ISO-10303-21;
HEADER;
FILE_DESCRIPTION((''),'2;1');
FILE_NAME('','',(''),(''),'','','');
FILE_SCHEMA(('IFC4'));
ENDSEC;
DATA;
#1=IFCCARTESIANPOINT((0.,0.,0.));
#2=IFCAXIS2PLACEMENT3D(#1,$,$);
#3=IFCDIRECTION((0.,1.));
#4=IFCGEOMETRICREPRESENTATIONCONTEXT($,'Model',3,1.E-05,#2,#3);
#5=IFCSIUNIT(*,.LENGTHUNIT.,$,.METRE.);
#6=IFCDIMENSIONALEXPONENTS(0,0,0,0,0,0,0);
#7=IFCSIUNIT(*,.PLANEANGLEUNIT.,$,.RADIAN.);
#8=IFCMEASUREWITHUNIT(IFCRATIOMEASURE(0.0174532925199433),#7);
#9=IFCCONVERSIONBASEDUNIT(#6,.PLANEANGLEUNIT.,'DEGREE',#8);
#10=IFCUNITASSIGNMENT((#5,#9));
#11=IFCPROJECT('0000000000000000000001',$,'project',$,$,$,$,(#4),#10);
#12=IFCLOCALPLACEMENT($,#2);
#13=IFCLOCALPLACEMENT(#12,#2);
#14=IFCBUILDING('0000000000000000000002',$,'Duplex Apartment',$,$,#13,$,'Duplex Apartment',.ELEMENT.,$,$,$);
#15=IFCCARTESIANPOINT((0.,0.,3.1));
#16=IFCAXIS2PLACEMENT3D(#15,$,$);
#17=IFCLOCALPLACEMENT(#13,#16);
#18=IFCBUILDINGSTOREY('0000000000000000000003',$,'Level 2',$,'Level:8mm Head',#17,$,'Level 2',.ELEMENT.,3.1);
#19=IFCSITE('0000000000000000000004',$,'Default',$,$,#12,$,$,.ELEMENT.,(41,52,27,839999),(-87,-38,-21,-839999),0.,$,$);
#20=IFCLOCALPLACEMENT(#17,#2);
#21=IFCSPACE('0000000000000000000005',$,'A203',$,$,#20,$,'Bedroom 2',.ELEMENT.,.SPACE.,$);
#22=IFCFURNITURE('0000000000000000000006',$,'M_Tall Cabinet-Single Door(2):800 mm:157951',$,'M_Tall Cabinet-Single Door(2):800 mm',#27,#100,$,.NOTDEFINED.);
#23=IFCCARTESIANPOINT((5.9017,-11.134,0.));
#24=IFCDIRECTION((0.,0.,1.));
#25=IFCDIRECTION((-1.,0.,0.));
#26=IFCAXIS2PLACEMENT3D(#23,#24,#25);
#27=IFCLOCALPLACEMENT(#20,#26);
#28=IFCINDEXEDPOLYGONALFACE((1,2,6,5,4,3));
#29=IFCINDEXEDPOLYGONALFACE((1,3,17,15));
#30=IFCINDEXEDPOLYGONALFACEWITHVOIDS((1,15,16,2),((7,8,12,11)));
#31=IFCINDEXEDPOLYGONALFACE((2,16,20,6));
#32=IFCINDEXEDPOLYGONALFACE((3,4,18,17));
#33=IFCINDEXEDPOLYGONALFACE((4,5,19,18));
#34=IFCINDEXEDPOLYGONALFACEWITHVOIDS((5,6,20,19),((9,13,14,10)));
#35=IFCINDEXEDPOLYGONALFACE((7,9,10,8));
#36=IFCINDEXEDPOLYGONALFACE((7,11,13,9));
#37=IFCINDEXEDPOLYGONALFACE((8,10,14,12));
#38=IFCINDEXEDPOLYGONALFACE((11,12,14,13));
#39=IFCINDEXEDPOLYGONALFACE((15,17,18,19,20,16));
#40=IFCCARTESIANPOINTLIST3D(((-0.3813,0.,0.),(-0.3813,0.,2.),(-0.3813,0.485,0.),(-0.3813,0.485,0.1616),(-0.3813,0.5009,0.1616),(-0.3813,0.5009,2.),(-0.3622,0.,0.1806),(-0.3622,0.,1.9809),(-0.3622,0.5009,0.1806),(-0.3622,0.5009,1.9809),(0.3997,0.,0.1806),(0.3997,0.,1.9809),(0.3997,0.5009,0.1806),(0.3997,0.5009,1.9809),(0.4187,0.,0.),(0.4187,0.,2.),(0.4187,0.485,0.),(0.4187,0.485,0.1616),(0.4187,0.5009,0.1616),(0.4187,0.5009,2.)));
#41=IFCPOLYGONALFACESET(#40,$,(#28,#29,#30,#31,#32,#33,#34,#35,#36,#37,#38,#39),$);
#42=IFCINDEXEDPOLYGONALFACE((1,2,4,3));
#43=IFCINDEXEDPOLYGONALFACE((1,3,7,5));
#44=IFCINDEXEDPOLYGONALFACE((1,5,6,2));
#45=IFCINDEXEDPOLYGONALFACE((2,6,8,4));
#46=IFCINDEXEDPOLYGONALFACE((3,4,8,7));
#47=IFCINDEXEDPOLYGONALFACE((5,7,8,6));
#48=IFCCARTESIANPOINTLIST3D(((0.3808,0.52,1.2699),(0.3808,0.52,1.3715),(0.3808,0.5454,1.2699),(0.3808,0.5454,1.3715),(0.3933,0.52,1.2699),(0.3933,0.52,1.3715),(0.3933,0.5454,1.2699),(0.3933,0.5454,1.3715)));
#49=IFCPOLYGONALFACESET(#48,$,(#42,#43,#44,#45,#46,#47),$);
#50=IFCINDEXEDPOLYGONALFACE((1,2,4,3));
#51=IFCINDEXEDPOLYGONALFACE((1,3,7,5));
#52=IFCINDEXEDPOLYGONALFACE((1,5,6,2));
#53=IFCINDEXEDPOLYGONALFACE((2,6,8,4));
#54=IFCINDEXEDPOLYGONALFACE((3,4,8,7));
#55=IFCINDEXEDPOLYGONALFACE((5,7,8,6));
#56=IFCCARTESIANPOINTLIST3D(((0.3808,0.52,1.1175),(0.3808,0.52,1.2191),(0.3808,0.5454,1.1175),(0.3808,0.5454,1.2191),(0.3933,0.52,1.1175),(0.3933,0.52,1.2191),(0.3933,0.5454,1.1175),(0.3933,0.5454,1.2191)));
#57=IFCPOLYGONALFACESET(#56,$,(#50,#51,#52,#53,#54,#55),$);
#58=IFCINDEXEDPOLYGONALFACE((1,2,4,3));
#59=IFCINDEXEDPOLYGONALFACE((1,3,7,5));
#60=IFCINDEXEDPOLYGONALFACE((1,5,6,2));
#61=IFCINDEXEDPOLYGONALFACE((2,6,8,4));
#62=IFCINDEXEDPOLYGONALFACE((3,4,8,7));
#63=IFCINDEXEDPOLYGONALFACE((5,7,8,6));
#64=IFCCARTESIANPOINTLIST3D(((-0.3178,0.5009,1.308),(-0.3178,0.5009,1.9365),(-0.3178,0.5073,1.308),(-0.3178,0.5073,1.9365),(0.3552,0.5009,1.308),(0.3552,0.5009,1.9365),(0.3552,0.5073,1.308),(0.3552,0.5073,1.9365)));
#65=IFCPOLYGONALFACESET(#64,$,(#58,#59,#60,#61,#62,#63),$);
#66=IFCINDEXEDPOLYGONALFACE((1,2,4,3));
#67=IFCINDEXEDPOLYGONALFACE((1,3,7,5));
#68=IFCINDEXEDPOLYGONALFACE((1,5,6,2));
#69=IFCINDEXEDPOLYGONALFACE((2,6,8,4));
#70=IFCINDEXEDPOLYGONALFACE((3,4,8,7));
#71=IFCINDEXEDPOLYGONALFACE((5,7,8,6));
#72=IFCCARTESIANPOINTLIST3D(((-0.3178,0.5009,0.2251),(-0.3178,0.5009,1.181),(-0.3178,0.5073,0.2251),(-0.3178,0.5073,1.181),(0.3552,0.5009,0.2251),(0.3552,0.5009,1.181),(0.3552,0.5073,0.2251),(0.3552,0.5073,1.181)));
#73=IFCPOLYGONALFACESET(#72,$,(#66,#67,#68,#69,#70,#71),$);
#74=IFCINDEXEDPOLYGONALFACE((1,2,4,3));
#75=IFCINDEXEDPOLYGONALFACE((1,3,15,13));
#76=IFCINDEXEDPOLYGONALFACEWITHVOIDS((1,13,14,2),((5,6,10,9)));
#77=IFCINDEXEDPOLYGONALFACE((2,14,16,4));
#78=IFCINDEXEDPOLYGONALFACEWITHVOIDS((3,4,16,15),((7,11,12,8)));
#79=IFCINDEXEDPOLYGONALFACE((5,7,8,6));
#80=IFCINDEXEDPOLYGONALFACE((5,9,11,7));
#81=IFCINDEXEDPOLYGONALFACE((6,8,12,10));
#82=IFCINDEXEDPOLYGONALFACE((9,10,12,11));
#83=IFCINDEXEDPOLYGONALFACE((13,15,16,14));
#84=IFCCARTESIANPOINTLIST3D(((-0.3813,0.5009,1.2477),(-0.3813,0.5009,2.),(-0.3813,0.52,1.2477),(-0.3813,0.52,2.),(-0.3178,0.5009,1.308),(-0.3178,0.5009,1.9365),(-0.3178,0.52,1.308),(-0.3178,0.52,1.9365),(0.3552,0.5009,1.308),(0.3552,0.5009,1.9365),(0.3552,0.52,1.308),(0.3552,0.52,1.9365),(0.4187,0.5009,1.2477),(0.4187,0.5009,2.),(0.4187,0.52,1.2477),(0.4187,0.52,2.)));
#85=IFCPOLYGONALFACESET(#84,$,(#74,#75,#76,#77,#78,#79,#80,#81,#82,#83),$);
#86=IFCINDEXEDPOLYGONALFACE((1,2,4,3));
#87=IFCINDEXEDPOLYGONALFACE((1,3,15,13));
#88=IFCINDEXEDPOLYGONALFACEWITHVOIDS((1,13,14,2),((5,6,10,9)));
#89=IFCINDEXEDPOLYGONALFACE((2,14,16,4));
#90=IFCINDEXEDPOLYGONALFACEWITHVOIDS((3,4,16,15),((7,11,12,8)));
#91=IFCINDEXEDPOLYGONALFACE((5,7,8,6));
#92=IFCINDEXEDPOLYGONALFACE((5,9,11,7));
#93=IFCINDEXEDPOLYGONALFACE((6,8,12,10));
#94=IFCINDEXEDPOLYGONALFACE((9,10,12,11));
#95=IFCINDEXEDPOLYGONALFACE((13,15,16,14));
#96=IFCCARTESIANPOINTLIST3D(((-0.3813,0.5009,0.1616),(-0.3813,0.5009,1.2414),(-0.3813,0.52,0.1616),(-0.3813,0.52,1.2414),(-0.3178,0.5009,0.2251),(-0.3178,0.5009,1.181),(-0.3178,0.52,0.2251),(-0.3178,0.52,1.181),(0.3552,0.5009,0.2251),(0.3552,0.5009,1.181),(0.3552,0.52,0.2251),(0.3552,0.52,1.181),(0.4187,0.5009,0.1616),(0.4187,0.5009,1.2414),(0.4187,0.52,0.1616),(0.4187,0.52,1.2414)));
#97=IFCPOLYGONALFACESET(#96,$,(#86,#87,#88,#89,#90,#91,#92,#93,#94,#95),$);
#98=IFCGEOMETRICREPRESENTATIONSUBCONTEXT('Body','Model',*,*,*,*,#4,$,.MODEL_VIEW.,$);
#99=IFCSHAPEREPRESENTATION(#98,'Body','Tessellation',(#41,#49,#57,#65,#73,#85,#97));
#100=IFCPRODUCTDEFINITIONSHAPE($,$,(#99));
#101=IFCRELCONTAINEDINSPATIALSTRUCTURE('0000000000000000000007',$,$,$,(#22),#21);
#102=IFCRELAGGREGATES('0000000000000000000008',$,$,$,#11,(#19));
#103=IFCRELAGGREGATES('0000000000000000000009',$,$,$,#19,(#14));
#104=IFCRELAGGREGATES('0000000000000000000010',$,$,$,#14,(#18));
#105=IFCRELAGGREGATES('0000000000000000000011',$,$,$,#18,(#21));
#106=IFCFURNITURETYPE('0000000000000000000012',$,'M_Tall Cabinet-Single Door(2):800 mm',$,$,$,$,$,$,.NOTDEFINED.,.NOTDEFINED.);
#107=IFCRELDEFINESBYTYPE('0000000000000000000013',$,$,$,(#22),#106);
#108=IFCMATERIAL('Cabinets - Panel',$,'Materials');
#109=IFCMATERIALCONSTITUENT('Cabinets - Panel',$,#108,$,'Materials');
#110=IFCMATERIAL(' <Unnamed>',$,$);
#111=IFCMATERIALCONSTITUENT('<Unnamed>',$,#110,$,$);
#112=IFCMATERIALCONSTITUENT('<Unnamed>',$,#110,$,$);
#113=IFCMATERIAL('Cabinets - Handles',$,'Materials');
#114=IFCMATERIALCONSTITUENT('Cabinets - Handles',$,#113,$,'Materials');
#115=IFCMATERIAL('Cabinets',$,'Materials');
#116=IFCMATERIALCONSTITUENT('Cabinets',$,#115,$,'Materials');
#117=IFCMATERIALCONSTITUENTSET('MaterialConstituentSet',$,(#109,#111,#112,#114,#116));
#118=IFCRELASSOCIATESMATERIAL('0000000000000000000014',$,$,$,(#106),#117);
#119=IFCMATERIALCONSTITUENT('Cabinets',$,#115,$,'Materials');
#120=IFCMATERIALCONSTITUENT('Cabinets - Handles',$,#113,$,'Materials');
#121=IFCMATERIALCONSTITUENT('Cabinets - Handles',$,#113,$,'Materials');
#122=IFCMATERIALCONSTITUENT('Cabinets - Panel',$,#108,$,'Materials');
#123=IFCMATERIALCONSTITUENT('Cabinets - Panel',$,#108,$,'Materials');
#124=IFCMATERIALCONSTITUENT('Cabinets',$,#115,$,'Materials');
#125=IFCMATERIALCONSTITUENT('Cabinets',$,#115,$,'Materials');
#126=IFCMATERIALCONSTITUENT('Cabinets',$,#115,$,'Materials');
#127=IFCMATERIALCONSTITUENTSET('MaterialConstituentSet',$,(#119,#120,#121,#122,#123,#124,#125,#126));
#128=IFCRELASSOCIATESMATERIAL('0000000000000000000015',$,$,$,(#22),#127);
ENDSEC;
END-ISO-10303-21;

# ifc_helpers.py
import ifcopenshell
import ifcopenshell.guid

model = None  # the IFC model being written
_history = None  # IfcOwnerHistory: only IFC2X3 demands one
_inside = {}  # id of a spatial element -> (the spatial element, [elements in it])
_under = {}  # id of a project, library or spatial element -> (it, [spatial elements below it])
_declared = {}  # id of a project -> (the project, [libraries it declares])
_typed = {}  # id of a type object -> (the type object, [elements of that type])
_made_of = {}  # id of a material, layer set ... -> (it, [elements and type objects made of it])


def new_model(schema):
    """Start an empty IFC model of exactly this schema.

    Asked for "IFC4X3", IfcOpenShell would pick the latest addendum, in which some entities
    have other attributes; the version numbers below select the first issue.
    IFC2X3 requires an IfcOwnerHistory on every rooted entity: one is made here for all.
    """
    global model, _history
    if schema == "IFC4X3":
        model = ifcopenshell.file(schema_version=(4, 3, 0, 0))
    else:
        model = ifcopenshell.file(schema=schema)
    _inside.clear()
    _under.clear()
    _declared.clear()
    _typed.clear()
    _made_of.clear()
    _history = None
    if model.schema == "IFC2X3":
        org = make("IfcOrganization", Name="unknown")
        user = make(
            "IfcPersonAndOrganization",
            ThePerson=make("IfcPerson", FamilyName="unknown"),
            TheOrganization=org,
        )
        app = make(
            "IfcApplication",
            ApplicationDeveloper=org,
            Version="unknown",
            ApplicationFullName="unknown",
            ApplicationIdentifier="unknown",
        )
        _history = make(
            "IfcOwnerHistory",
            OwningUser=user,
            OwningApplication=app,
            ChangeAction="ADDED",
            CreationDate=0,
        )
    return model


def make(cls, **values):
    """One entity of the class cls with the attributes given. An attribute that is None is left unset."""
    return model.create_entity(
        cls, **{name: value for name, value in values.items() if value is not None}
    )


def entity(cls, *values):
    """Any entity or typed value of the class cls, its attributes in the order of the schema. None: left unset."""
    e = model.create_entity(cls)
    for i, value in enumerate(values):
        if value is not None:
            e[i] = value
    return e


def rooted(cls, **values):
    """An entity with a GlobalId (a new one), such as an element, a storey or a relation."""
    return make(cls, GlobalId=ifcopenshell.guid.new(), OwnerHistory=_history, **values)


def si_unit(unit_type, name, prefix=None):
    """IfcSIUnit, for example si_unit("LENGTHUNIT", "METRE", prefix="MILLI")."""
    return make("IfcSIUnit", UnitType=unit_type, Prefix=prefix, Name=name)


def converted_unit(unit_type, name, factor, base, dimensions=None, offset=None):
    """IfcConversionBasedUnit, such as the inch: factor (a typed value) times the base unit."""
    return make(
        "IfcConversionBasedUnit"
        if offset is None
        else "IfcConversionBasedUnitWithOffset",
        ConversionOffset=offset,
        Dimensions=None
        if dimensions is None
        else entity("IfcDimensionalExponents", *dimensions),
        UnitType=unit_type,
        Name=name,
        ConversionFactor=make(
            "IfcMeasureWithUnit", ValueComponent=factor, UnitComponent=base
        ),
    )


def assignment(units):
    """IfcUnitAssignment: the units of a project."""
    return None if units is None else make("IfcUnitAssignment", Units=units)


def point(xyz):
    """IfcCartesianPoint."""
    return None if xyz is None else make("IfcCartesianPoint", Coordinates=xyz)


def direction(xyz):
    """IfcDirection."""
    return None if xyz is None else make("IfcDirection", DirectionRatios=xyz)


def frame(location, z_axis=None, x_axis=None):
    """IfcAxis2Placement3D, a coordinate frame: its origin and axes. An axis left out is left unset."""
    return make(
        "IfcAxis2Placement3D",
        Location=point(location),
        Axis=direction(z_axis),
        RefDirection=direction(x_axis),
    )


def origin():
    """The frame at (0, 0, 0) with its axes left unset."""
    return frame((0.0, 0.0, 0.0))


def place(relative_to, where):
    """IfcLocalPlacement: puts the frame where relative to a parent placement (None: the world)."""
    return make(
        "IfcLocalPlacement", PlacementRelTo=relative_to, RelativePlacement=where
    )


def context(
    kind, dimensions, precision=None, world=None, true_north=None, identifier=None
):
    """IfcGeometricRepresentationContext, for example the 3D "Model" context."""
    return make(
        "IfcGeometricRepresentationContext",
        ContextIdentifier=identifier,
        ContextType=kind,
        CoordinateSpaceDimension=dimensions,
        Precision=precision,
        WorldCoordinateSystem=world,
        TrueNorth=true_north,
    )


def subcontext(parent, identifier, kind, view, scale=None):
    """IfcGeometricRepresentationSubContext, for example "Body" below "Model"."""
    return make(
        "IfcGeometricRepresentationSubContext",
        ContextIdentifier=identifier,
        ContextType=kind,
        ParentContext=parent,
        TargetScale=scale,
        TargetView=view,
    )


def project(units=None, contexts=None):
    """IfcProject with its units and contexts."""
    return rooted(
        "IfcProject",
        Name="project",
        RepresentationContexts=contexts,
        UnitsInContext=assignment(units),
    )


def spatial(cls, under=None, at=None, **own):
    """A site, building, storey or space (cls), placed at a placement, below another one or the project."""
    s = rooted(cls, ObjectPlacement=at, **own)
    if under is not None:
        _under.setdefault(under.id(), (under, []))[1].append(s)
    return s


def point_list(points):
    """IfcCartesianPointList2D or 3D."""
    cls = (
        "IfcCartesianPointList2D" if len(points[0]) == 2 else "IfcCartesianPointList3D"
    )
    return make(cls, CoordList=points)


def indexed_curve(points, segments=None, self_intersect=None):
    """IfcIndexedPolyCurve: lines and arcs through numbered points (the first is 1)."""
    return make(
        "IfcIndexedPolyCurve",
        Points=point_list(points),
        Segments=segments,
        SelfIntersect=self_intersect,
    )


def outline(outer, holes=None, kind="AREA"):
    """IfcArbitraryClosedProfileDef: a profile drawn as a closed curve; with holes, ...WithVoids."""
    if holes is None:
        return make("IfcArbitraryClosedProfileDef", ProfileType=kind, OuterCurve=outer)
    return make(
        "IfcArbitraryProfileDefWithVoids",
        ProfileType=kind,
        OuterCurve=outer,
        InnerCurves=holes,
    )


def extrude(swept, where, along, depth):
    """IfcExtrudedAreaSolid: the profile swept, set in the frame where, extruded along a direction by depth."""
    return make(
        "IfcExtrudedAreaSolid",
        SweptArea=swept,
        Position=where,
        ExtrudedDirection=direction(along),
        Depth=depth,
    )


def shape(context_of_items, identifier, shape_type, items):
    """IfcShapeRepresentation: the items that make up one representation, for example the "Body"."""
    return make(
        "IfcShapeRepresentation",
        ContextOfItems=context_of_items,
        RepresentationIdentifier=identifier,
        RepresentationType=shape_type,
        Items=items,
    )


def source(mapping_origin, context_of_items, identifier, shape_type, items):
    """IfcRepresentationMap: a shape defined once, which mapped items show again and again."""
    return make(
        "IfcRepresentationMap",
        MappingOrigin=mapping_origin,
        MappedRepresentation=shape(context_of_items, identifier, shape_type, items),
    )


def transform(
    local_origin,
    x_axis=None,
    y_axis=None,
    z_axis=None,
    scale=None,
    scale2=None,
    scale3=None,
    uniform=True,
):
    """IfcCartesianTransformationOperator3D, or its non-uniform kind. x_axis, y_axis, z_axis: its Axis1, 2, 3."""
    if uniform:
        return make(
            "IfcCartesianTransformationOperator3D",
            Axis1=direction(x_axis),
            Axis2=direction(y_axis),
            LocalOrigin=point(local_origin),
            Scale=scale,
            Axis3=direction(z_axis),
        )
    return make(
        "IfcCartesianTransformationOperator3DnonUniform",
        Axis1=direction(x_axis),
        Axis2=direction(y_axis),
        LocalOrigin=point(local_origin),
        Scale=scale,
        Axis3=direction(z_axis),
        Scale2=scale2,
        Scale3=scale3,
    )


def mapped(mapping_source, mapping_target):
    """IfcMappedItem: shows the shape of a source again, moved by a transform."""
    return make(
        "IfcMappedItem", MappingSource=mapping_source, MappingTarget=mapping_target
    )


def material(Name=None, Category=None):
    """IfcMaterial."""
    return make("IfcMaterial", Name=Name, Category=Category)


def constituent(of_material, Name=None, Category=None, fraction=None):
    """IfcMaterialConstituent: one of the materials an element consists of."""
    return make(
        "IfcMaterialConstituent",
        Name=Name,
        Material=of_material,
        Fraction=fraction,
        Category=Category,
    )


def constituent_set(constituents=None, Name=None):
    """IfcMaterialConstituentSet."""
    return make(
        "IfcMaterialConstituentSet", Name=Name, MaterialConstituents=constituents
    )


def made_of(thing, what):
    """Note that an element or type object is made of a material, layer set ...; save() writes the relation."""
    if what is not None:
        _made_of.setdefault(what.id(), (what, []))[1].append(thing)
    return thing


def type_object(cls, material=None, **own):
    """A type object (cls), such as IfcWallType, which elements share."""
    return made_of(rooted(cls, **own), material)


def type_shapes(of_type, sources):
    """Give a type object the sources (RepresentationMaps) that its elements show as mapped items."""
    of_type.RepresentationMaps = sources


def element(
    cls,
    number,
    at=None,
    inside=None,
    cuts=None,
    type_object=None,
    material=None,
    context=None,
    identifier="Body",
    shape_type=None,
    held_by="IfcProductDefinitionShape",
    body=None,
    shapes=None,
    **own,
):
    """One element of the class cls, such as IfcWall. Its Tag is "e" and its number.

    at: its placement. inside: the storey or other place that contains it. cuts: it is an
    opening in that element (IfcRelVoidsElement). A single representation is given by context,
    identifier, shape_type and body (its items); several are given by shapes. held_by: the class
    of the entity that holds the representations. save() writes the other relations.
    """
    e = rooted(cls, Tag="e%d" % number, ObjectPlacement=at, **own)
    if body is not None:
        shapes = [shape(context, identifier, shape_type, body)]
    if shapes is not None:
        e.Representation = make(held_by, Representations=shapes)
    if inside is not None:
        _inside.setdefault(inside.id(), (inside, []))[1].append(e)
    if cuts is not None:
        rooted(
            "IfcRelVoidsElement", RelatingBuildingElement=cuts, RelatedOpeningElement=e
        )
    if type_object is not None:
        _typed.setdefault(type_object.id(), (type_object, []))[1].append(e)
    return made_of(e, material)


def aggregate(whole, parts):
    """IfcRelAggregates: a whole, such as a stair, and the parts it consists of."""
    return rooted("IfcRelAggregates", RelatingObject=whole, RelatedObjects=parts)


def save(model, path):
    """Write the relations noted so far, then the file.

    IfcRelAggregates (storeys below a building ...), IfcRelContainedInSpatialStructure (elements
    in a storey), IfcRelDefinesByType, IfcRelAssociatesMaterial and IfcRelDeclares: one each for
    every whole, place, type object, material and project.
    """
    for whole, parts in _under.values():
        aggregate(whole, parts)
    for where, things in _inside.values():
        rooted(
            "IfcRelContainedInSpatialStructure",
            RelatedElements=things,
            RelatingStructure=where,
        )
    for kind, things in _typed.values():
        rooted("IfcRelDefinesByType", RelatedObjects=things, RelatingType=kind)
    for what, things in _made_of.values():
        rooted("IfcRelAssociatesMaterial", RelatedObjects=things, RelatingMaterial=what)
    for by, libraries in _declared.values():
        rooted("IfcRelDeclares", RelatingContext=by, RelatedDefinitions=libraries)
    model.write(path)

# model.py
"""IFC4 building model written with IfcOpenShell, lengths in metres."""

from ifc_helpers import new_model, entity, si_unit, converted_unit, direction, frame, origin, place, context, subcontext, project, spatial, indexed_curve, outline, extrude, source, transform, mapped, material, constituent, constituent_set, type_object, type_shapes, element, save


model = new_model("IFC4")

# Units and contexts
model_context = context("Model", 3, precision=1e-05, world=origin(), true_north=direction((0.0, 1.0)))
body_context = subcontext(model_context, "Body", "Model", "MODEL_VIEW")
ifc_project = project(units=[si_unit("LENGTHUNIT", "METRE"), converted_unit("PLANEANGLEUNIT", "DEGREE", entity("IfcRatioMeasure", 0.0174532925199433), si_unit("PLANEANGLEUNIT", "RADIAN"), dimensions=[0, 0, 0, 0, 0, 0, 0])], contexts=[model_context])

# Site, building, storey
site_placement = place(None, origin())
site = spatial("IfcSite", under=ifc_project, at=site_placement, Name="Default", CompositionType="ELEMENT", RefLatitude=(41, 52, 27, 839999), RefLongitude=(-87, -38, -21, -839999), RefElevation=0.0)
building_placement = place(site_placement, origin())
building = spatial("IfcBuilding", under=site, at=building_placement, Name="Duplex Apartment", LongName="Duplex Apartment", CompositionType="ELEMENT")
storey_placement = place(building_placement, frame((0.0, 0.0, 3.1)))
storey = spatial("IfcBuildingStorey", under=building, at=storey_placement, Name="Level 2", ObjectType="Level:8mm Head", LongName="Level 2", CompositionType="ELEMENT", Elevation=3.1)

# Shared definitions
space_1_placement = place(storey_placement, origin())
space_1 = spatial("IfcSpace", under=storey, at=space_1_placement, Name="A203", LongName="Bedroom 2", CompositionType="ELEMENT", PredefinedType="SPACE")

# Furniture, opening
ifc_material_1 = material(Name="Cabinets", Category="Materials")
ifc_constituent_1 = constituent(ifc_material_1, Name="Cabinets", Category="Materials")
ifc_material_2 = material(Name="Cabinets - Handles", Category="Materials")
ifc_constituent_2 = constituent(ifc_material_2, Name="Cabinets - Handles", Category="Materials")
ifc_constituent_3 = constituent(ifc_material_2, Name="Cabinets - Handles", Category="Materials")
ifc_material_3 = material(Name="Cabinets - Panel", Category="Materials")
ifc_constituent_4 = constituent(ifc_material_3, Name="Cabinets - Panel", Category="Materials")
ifc_constituent_5 = constituent(ifc_material_3, Name="Cabinets - Panel", Category="Materials")
ifc_constituent_6 = constituent(ifc_material_1, Name="Cabinets", Category="Materials")
ifc_constituent_7 = constituent(ifc_material_1, Name="Cabinets", Category="Materials")
ifc_constituent_8 = constituent(ifc_material_1, Name="Cabinets", Category="Materials")
ifc_constituent_set_1 = constituent_set(constituents=[ifc_constituent_1, ifc_constituent_2, ifc_constituent_3, ifc_constituent_4, ifc_constituent_5, ifc_constituent_6, ifc_constituent_7, ifc_constituent_8], Name="MaterialConstituentSet")
ifc_constituent_9 = constituent(ifc_material_3, Name="Cabinets - Panel", Category="Materials")
ifc_material_4 = material(Name=" <Unnamed>")
ifc_constituent_10 = constituent(ifc_material_4, Name="<Unnamed>")
ifc_constituent_11 = constituent(ifc_material_4, Name="<Unnamed>")
ifc_constituent_12 = constituent(ifc_material_2, Name="Cabinets - Handles", Category="Materials")
ifc_constituent_13 = constituent(ifc_material_1, Name="Cabinets", Category="Materials")
ifc_constituent_set_2 = constituent_set(constituents=[ifc_constituent_9, ifc_constituent_10, ifc_constituent_11, ifc_constituent_12, ifc_constituent_13], Name="MaterialConstituentSet")
furniture_type_1 = type_object("IfcFurnitureType", Name="M_Tall Cabinet-Single Door(2):800 mm", AssemblyPlace="NOTDEFINED", PredefinedType="NOTDEFINED", material=ifc_constituent_set_2)
shared_shape_1 = source(origin(), body_context, "Body", "SweptSolid", [
    extrude(outline(indexed_curve([(-0.5589, -0.1723), (1.2795, -0.1723), (1.2795, 0.3286), (-0.7205, 0.3286), (-0.7205, -0.1563), (-0.5589, -0.1563), (-0.5589, -0.1723)], self_intersect=False)), frame((-0.3813, 0.3286, 0.7205), z_axis=(1.0, 0.0, 0.0), x_axis=(0.0, 0.0, 1.0)), (0.0, 0.0, 1.0), 0.8),
    extrude(outline(indexed_curve([(-0.0063, -0.0127), (0.0063, -0.0127), (0.0063, 0.0127), (-0.0063, 0.0127), (-0.0063, -0.0127)], self_intersect=False)), frame((0.3871, 0.5327, 1.2699), z_axis=(0.0, 0.0, 1.0), x_axis=(-1.0, 0.0, 0.0)), (0.0, 0.0, 1.0), 0.1016),
    extrude(outline(indexed_curve([(-0.0063, -0.0127), (0.0063, -0.0127), (0.0063, 0.0127), (-0.0063, 0.0127), (-0.0063, -0.0127)], self_intersect=False)), frame((0.3871, 0.5327, 1.1175), z_axis=(0.0, 0.0, 1.0), x_axis=(-1.0, 0.0, 0.0)), (0.0, 0.0, 1.0), 0.1016),
    extrude(outline(indexed_curve([(-0.3365, -0.0032), (0.3365, -0.0032), (0.3365, 0.0032), (-0.3365, 0.0032), (-0.3365, -0.0032)], self_intersect=False)), frame((0.0187, 0.5041, 1.308), z_axis=(0.0, 0.0, 1.0), x_axis=(-1.0, 0.0, 0.0)), (0.0, 0.0, 1.0), 0.6285),
    extrude(outline(indexed_curve([(-0.3365, -0.0032), (0.3365, -0.0032), (0.3365, 0.0032), (-0.3365, 0.0032), (-0.3365, -0.0032)], self_intersect=False)), frame((0.0187, 0.5041, 0.2251), z_axis=(0.0, 0.0, 1.0), x_axis=(-1.0, 0.0, 0.0)), (0.0, 0.0, 1.0), 0.956),
    extrude(outline(indexed_curve([(-0.3761, -0.4), (0.3761, -0.4), (0.3761, 0.4), (-0.3761, 0.4), (-0.3761, -0.4)], self_intersect=False), holes=[indexed_curve([(-0.3126, -0.3365), (-0.3126, 0.3365), (0.3158, 0.3365), (0.3158, -0.3365), (-0.3126, -0.3365)], self_intersect=False)]), frame((0.0187, 0.501, 1.6239), z_axis=(0.0, 1.0, 0.0), x_axis=(0.0, 0.0, -1.0)), (0.0, 0.0, 1.0), 0.0191),
    extrude(outline(indexed_curve([(-0.4, -0.5399), (0.4, -0.5399), (0.4, 0.5399), (-0.4, 0.5399), (-0.4, -0.5399)], self_intersect=False), holes=[indexed_curve([(-0.3365, 0.4796), (0.3365, 0.4796), (0.3365, -0.4764), (-0.3365, -0.4764), (-0.3365, 0.4796)], self_intersect=False)]), frame((0.0187, 0.501, 0.7015), z_axis=(0.0, 1.0, 0.0), x_axis=(-1.0, 0.0, 0.0)), (0.0, 0.0, 1.0), 0.0191),
    extrude(outline(indexed_curve([(-0.381, -0.0095), (0.381, -0.0095), (0.381, 0.0095), (-0.381, 0.0095), (-0.381, -0.0095)], self_intersect=False)), frame((0.0187, 0.0095, 0.1806), z_axis=(0.0, 0.0, 1.0), x_axis=(-1.0, 0.0, 0.0)), (0.0, 0.0, 1.0), 1.8003),
])
type_shapes(furniture_type_1, [shared_shape_1])
furniture_1_placement = place(space_1_placement, frame((5.9017, -11.134, 0.0), z_axis=(0.0, 0.0, 1.0), x_axis=(-1.0, 0.0, 0.0)))
furniture_1 = element("IfcFurniture", 1, at=furniture_1_placement, inside=space_1, type_object=furniture_type_1, material=ifc_constituent_set_1, Name="M_Tall Cabinet-Single Door(2):800 mm:157951", ObjectType="M_Tall Cabinet-Single Door(2):800 mm", PredefinedType="NOTDEFINED", context=body_context, shape_type="MappedRepresentation", body=[
    mapped(shared_shape_1, transform((0.0, 0.0, 0.0), scale=1.0)),
])
opening_1_placement = place(storey_placement, frame((5.9017, -11.134, 3.1)))
element("IfcOpeningElement", 2, at=opening_1_placement, cuts=furniture_1, ObjectType="Opening", PredefinedType="OPENING", context=body_context, shape_type="SweptSolid", body=[
    extrude(outline(indexed_curve([(-0.9002, -0.381), (0.9002, -0.381), (0.9002, 0.381), (-0.9002, 0.381), (-0.9002, -0.381)], self_intersect=False)), frame((-0.0187, 0.0, -2.0192), z_axis=(0.0, -1.0, 0.0), x_axis=(0.0, 0.0, -1.0)), (0.0, 0.0, 1.0), 0.501),
])

save(model, "model.ifc")
